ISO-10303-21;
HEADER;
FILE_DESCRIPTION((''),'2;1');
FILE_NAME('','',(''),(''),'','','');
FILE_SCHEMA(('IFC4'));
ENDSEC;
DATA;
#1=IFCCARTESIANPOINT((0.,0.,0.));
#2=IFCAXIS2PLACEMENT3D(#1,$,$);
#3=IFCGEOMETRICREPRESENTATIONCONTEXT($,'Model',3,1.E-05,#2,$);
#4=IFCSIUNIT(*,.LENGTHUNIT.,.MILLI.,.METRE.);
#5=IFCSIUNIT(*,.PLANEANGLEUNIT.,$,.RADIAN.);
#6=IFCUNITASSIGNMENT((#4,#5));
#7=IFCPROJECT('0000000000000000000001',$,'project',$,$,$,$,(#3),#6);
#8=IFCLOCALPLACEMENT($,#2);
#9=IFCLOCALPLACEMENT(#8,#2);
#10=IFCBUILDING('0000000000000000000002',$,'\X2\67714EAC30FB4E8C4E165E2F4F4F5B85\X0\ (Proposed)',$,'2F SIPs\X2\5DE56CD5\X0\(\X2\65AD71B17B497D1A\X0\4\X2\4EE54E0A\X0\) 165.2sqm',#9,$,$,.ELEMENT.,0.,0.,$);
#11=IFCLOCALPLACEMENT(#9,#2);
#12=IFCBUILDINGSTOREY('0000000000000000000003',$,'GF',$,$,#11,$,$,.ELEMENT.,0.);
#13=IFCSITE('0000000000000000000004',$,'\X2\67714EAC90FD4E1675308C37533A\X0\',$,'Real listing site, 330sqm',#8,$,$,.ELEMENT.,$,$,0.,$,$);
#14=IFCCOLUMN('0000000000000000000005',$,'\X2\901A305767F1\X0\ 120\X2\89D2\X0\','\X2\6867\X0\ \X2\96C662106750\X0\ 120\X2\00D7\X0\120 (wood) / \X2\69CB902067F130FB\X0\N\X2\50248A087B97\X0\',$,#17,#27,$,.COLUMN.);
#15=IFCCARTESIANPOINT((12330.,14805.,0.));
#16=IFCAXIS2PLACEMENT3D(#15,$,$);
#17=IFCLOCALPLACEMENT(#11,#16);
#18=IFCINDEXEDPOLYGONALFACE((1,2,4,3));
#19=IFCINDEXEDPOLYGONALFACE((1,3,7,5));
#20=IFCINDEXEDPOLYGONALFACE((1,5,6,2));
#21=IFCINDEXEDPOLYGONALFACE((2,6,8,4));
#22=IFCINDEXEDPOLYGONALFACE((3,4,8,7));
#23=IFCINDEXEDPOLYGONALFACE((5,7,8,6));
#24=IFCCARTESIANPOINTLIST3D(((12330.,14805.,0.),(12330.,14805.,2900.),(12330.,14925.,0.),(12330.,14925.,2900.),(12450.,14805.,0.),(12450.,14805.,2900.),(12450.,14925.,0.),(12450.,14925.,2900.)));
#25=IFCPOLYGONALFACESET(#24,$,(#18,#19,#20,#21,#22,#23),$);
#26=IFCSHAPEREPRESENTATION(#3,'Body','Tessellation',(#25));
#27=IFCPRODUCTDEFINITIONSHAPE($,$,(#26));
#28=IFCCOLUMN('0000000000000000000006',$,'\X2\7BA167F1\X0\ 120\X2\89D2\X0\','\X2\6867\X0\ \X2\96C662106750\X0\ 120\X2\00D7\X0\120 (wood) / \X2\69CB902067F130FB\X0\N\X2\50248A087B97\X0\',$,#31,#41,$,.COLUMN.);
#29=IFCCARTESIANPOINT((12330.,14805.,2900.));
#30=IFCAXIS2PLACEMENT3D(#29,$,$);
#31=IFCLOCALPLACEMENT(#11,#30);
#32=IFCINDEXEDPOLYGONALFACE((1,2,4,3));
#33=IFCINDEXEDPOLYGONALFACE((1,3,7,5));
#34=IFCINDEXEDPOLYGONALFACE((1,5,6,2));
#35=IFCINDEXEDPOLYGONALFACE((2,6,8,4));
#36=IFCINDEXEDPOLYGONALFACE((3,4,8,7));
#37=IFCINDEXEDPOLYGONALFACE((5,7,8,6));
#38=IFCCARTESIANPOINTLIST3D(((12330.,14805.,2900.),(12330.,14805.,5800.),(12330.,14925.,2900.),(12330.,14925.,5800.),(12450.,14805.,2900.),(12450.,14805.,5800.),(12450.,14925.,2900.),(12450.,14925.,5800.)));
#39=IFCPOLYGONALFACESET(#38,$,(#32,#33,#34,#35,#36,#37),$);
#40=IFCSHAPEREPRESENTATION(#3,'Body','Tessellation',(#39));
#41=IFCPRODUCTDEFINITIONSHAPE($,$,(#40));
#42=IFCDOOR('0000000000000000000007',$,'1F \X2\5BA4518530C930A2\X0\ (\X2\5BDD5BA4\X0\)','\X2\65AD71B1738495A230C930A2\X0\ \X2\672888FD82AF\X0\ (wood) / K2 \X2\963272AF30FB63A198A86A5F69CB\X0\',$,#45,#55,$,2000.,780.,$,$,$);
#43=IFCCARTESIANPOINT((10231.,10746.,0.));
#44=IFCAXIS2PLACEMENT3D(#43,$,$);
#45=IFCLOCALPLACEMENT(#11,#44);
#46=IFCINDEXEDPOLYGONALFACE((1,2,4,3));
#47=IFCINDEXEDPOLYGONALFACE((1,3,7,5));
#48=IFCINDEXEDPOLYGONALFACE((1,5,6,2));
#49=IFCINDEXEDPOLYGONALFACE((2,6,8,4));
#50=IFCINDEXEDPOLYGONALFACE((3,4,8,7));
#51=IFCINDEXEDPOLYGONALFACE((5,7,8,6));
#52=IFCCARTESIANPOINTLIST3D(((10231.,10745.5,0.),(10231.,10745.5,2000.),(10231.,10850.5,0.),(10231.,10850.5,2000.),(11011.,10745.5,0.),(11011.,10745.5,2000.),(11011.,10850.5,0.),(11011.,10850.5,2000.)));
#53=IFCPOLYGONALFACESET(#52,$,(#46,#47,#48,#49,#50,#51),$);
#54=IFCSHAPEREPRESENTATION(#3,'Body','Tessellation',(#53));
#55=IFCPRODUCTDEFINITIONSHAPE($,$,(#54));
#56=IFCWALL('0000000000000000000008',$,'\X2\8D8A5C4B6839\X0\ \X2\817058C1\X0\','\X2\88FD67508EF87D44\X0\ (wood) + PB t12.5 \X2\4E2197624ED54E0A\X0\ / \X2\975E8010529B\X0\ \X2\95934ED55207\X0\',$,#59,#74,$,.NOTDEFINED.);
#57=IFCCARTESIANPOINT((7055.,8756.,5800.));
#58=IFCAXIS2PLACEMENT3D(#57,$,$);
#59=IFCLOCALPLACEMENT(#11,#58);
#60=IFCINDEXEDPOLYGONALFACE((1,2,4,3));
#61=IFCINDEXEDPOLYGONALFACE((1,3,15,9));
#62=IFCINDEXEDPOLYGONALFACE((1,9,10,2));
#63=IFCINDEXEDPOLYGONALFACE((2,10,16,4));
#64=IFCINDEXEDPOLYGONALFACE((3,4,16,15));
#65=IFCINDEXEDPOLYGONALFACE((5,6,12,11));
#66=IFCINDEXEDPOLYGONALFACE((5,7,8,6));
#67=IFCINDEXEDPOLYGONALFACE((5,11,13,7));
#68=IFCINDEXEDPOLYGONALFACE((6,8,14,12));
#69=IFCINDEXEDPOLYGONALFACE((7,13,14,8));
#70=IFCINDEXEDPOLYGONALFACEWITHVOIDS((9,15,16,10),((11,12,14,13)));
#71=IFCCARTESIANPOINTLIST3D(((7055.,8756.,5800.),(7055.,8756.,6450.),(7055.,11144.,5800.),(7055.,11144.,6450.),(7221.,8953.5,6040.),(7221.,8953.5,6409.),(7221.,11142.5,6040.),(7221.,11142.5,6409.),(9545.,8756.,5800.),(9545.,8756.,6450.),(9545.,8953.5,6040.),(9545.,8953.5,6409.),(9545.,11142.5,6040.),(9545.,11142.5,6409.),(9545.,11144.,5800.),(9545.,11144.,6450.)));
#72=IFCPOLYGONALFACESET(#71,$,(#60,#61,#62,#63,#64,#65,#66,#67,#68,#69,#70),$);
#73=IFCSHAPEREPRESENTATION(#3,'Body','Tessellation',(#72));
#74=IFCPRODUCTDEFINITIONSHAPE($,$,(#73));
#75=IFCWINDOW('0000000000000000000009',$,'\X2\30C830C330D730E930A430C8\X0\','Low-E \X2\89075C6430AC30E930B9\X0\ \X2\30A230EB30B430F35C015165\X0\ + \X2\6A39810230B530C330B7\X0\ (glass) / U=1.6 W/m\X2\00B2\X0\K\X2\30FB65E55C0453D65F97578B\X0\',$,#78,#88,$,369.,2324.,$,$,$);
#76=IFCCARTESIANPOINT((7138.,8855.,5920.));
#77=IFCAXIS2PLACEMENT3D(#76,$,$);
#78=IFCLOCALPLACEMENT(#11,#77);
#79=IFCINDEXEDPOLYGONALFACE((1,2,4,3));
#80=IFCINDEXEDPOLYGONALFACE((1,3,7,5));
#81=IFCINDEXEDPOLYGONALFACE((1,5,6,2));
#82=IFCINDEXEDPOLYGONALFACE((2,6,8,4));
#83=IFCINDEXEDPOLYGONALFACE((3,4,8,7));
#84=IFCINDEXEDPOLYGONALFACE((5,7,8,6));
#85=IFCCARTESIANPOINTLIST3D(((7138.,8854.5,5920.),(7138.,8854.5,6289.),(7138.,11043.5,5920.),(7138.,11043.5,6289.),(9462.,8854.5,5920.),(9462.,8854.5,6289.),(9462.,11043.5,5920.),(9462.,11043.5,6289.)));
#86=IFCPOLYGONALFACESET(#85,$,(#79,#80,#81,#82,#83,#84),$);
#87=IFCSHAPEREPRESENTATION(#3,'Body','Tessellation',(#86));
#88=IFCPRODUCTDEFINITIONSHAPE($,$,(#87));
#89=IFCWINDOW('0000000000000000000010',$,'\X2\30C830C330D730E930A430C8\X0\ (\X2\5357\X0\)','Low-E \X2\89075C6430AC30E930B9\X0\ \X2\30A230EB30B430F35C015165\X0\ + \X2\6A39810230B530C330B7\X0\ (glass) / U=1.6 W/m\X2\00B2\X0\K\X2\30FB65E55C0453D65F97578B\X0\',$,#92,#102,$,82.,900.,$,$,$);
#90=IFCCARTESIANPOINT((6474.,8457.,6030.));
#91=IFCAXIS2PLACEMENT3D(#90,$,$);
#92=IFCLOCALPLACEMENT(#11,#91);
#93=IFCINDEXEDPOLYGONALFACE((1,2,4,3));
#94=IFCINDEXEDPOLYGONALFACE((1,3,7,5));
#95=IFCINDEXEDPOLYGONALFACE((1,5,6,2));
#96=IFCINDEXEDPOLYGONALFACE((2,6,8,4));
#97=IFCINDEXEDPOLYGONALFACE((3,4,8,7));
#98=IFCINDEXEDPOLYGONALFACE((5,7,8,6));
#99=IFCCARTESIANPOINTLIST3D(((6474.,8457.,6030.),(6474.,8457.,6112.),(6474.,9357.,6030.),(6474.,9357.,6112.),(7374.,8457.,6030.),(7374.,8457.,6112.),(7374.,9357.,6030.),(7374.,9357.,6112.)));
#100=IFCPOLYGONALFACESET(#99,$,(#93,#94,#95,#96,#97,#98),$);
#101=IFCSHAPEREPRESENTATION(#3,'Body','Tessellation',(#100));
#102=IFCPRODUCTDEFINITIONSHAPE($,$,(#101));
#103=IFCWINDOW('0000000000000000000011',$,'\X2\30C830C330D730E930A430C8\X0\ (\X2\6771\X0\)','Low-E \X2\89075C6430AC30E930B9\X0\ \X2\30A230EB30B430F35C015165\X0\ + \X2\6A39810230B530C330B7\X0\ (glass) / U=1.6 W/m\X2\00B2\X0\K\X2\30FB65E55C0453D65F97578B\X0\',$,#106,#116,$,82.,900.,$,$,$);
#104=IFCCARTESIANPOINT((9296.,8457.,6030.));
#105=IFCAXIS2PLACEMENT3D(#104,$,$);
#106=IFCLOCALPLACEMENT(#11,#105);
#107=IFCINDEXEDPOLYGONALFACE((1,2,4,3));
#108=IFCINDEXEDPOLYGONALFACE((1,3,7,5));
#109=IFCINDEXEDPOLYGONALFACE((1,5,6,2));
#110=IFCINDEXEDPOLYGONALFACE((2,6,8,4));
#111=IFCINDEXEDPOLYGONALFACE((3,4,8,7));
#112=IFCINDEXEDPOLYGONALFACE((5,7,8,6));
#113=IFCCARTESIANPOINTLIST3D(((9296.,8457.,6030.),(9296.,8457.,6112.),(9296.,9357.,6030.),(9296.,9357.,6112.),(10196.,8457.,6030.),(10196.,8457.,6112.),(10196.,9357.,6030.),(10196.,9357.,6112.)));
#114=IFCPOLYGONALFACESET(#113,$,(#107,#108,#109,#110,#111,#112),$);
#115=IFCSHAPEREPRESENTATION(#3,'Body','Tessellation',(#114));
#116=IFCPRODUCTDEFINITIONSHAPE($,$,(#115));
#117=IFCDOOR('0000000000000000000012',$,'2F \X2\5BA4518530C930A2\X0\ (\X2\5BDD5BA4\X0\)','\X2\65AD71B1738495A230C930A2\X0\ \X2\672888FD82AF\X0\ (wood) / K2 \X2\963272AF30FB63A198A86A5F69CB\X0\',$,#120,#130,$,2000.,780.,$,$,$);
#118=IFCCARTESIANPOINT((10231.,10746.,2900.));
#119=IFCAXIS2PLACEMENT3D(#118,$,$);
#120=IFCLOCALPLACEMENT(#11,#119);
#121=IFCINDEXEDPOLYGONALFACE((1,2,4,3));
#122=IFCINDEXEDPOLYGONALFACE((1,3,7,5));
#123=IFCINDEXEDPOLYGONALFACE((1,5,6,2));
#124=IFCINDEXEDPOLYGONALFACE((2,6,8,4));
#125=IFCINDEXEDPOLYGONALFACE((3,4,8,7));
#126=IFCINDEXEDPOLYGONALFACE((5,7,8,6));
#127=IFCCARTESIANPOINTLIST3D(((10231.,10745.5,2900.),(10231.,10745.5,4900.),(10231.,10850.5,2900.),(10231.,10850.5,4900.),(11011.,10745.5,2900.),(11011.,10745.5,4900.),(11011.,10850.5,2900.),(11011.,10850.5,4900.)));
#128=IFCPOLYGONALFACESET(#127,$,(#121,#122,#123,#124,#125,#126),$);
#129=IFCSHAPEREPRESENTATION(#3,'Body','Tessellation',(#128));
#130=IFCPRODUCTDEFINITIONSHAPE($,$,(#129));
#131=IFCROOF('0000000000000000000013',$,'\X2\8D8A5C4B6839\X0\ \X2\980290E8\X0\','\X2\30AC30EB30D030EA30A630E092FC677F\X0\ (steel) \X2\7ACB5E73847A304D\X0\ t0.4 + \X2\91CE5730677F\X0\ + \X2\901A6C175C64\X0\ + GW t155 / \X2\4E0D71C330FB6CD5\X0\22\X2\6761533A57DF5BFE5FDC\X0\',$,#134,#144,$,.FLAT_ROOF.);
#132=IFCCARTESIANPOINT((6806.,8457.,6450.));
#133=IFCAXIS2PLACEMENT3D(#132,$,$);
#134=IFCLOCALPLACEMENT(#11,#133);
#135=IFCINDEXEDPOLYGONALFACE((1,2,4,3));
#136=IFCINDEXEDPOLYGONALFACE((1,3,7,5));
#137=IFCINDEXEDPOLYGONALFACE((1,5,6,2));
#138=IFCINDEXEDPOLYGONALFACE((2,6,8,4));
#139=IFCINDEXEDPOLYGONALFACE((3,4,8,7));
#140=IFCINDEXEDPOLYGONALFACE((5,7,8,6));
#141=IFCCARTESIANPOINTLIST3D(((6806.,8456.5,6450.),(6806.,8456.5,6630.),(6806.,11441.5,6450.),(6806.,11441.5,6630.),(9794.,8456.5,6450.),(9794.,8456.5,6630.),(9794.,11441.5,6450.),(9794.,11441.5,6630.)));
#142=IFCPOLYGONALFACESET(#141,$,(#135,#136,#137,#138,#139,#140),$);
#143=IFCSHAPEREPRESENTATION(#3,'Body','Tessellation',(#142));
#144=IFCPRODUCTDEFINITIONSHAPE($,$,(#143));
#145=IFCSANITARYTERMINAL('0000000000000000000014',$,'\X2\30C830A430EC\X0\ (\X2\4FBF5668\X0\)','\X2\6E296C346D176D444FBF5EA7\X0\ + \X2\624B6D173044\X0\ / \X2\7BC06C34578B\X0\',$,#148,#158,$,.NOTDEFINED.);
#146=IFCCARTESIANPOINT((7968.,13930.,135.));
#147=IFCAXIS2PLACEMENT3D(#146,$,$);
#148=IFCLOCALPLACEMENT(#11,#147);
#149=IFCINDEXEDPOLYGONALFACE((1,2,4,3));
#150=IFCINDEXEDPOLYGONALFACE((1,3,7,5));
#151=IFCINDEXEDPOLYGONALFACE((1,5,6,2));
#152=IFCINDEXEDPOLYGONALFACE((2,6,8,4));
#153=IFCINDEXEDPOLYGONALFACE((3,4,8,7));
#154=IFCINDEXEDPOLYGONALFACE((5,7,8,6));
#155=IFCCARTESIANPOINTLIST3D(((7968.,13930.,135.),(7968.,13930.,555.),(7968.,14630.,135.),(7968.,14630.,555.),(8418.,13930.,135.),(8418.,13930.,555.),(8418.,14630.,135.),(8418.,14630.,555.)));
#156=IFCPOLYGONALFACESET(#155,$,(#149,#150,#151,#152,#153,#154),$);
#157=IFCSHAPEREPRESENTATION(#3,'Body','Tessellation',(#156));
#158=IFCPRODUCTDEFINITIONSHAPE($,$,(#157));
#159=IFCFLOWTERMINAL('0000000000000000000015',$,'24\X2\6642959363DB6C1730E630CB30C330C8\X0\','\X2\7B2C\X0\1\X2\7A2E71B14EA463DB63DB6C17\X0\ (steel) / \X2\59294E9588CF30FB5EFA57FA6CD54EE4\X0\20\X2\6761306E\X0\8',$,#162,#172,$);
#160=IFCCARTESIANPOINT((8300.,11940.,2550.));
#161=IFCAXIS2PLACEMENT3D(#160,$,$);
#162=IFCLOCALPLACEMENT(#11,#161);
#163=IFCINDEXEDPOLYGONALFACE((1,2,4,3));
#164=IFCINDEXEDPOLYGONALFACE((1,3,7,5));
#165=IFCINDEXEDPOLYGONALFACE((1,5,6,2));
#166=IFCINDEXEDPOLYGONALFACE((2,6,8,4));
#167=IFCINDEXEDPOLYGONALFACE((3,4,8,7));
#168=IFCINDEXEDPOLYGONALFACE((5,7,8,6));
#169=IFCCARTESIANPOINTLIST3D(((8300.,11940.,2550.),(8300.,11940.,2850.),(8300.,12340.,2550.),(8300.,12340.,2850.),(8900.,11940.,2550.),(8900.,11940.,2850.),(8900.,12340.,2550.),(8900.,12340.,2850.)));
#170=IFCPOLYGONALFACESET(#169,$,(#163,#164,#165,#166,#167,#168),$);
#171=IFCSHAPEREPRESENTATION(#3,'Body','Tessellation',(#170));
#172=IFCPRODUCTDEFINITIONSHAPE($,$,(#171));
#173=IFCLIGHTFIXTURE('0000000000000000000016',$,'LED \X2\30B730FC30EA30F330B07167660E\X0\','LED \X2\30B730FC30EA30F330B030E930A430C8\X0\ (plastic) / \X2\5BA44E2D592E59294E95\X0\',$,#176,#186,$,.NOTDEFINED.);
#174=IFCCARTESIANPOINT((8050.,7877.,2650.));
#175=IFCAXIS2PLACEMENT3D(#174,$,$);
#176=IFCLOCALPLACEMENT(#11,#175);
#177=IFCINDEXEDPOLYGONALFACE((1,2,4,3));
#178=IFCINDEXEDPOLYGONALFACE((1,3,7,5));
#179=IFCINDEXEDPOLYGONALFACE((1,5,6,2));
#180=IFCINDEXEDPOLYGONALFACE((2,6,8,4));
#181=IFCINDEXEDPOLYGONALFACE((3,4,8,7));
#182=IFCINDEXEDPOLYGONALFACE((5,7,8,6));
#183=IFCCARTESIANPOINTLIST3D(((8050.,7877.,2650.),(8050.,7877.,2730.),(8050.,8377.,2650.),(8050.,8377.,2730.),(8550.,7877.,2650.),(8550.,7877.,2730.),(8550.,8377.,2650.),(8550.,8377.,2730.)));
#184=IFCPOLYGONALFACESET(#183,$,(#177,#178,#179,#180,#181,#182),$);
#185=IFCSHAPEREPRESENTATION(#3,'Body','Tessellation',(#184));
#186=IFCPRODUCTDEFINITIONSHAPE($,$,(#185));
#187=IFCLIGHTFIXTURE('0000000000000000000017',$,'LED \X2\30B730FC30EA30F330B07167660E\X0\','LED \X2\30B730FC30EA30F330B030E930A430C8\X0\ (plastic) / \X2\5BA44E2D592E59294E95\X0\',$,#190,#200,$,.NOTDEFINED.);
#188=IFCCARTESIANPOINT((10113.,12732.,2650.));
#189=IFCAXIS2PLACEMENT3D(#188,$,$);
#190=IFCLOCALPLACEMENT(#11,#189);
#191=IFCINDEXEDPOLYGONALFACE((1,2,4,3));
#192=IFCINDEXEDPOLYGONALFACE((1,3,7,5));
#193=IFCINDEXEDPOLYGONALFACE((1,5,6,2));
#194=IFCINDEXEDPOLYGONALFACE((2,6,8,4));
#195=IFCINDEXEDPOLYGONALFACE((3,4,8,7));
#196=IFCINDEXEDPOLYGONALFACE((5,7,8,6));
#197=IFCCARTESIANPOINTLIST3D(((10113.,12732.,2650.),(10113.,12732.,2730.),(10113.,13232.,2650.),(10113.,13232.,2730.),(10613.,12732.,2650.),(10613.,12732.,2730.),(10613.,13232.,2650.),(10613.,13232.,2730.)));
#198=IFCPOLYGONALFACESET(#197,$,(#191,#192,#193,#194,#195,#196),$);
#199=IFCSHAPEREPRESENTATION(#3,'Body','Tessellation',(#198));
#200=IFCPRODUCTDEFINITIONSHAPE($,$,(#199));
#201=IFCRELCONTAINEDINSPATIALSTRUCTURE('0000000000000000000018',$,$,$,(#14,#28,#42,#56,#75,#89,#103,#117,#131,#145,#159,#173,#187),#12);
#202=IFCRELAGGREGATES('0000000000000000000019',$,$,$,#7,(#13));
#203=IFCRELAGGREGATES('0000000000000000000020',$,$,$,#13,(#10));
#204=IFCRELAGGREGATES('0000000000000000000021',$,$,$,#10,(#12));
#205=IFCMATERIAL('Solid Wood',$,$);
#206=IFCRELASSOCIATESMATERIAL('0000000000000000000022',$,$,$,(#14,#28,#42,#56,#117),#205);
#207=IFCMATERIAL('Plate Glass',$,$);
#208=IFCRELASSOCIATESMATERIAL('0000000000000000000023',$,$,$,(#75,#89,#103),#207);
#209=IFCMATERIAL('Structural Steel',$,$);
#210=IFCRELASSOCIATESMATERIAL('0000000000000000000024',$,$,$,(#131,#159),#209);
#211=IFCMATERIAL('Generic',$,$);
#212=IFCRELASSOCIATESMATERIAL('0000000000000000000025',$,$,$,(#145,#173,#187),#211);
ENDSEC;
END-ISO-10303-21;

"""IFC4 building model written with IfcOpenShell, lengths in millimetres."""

from ifc_helpers import new_model, si_unit, frame, frame_2d, origin, place, context, project, spatial, rectangle, extrude, material, element, fill, save


model = new_model("IFC4")

# Units and contexts
model_context = context("Model", 3, precision=1e-05, world=origin())
ifc_project = project(units=[si_unit("LENGTHUNIT", "METRE", prefix="MILLI"), si_unit("PLANEANGLEUNIT", "RADIAN")], contexts=[model_context])

# Site, building, storey
site_placement = place(None, origin())
site = spatial("IfcSite", under=ifc_project, at=site_placement, Name="東京都世田谷区", ObjectType="Real listing site, 330sqm", CompositionType="ELEMENT", RefElevation=0.0)
building_placement = place(site_placement, origin())
building = spatial("IfcBuilding", under=site, at=building_placement, Name="東京・二世帯住宅 (Proposed)", ObjectType="2F SIPs工法(断熱等級4以上) 165.2sqm", CompositionType="ELEMENT", ElevationOfRefHeight=0.0, ElevationOfTerrain=0.0)
storey_placement = place(building_placement, origin())
storey = spatial("IfcBuildingStorey", under=building, at=storey_placement, Name="GF", CompositionType="ELEMENT", Elevation=0.0)

# Columns
ifc_material_1 = material(Name="Solid Wood")
column_1_placement = place(storey_placement, frame((12330.0, 14805.0, 0.0)))
element("IfcColumn", 1, at=column_1_placement, inside=storey, material=ifc_material_1, Name="通し柱 120角", Description="桧 集成材 120×120 (wood) / 構造柱・N値計算", PredefinedType="COLUMN", context=model_context, shape_type="SweptSolid", body=[
    extrude(rectangle(XDim=120.0, YDim=120.0, at=frame_2d((60.0, 60.0))), frame((12330.0, 14805.0, 0.0)), (0.0, 0.0, 1.0), 2900.0),
])
column_2_placement = place(storey_placement, frame((12330.0, 14805.0, 2900.0)))
element("IfcColumn", 2, at=column_2_placement, inside=storey, material=ifc_material_1, Name="管柱 120角", Description="桧 集成材 120×120 (wood) / 構造柱・N値計算", PredefinedType="COLUMN", context=model_context, shape_type="SweptSolid", body=[
    extrude(rectangle(XDim=120.0, YDim=120.0, at=frame_2d((60.0, 60.0))), frame((12330.0, 14805.0, 2900.0)), (0.0, 0.0, 1.0), 2900.0),
])

# Door
door_1_placement = place(storey_placement, frame((10231.0, 10746.0, 0.0)))
element("IfcDoor", 3, at=door_1_placement, inside=storey, material=ifc_material_1, Name="1F 室内ドア (寝室)", Description="断熱玄関ドア 木製芯 (wood) / K2 防犯・採風機構", OverallHeight=2000.0, OverallWidth=780.0, context=model_context, shape_type="SweptSolid", body=[
    extrude(rectangle(XDim=780.0, YDim=105.0, at=frame_2d((390.0, 52.0))), frame((10231.0, 10746.0, 0.0)), (0.0, 0.0, 1.0), 2000.0),
])

# Wall, openings, windows
wall_1_placement = place(storey_placement, frame((7055.0, 8756.0, 5800.0)))
wall_1 = element("IfcWall", 4, at=wall_1_placement, inside=storey, material=ifc_material_1, Name="越屋根 腰壁", Description="製材軸組 (wood) + PB t12.5 両面仕上 / 非耐力 間仕切", PredefinedType="NOTDEFINED", context=model_context, shape_type="SweptSolid", body=[
    extrude(rectangle(XDim=2490.0, YDim=2388.0, at=frame_2d((1245.0, 1194.0))), frame((7055.0, 8756.0, 5800.0)), (0.0, 0.0, 1.0), 650.0),
])
opening_1_placement = place(storey_placement, frame((7138.0, 8855.0, 5920.0)))
opening_1 = element("IfcOpeningElement", 5, at=opening_1_placement, cuts=wall_1, PredefinedType="NOTDEFINED", context=model_context, shape_type="SweptSolid", body=[
    extrude(rectangle(XDim=2324.0, YDim=2189.0, at=frame_2d((1162.0, 1094.0))), frame((7138.0, 8855.0, 5920.0)), (0.0, 0.0, 1.0), 369.0),
])
opening_2_placement = place(storey_placement, frame((6474.0, 8457.0, 6030.0)))
opening_2 = element("IfcOpeningElement", 6, at=opening_2_placement, cuts=wall_1, PredefinedType="NOTDEFINED", context=model_context, shape_type="SweptSolid", body=[
    extrude(rectangle(XDim=900.0, YDim=900.0, at=frame_2d((450.0, 450.0))), frame((6474.0, 8457.0, 6030.0)), (0.0, 0.0, 1.0), 82.0),
])
opening_3_placement = place(storey_placement, frame((9296.0, 8457.0, 6030.0)))
opening_3 = element("IfcOpeningElement", 7, at=opening_3_placement, cuts=wall_1, PredefinedType="NOTDEFINED", context=model_context, shape_type="SweptSolid", body=[
    extrude(rectangle(XDim=900.0, YDim=900.0, at=frame_2d((450.0, 450.0))), frame((9296.0, 8457.0, 6030.0)), (0.0, 0.0, 1.0), 82.0),
])
ifc_material_2 = material(Name="Plate Glass")
window_1_placement = place(storey_placement, frame((7138.0, 8855.0, 5920.0)))
window_1 = element("IfcWindow", 8, at=window_1_placement, inside=storey, material=ifc_material_2, Name="トップライト", Description="Low-E 複層ガラス アルゴン封入 + 樹脂サッシ (glass) / U=1.6 W/m²K・日射取得型", OverallHeight=369.0, OverallWidth=2324.0, context=model_context, shape_type="SweptSolid", body=[
    extrude(rectangle(XDim=2324.0, YDim=2189.0, at=frame_2d((1162.0, 1094.0))), frame((7138.0, 8855.0, 5920.0)), (0.0, 0.0, 1.0), 369.0),
])
fill(opening_1, window_1)
window_2_placement = place(storey_placement, frame((6474.0, 8457.0, 6030.0)))
window_2 = element("IfcWindow", 9, at=window_2_placement, inside=storey, material=ifc_material_2, Name="トップライト (南)", Description="Low-E 複層ガラス アルゴン封入 + 樹脂サッシ (glass) / U=1.6 W/m²K・日射取得型", OverallHeight=82.0, OverallWidth=900.0, context=model_context, shape_type="SweptSolid", body=[
    extrude(rectangle(XDim=900.0, YDim=900.0, at=frame_2d((450.0, 450.0))), frame((6474.0, 8457.0, 6030.0)), (0.0, 0.0, 1.0), 82.0),
])
fill(opening_2, window_2)
window_3_placement = place(storey_placement, frame((9296.0, 8457.0, 6030.0)))
window_3 = element("IfcWindow", 10, at=window_3_placement, inside=storey, material=ifc_material_2, Name="トップライト (東)", Description="Low-E 複層ガラス アルゴン封入 + 樹脂サッシ (glass) / U=1.6 W/m²K・日射取得型", OverallHeight=82.0, OverallWidth=900.0, context=model_context, shape_type="SweptSolid", body=[
    extrude(rectangle(XDim=900.0, YDim=900.0, at=frame_2d((450.0, 450.0))), frame((9296.0, 8457.0, 6030.0)), (0.0, 0.0, 1.0), 82.0),
])
fill(opening_3, window_3)

# Door
door_2_placement = place(storey_placement, frame((10231.0, 10746.0, 2900.0)))
element("IfcDoor", 11, at=door_2_placement, inside=storey, material=ifc_material_1, Name="2F 室内ドア (寝室)", Description="断熱玄関ドア 木製芯 (wood) / K2 防犯・採風機構", OverallHeight=2000.0, OverallWidth=780.0, context=model_context, shape_type="SweptSolid", body=[
    extrude(rectangle(XDim=780.0, YDim=105.0, at=frame_2d((390.0, 52.0))), frame((10231.0, 10746.0, 2900.0)), (0.0, 0.0, 1.0), 2000.0),
])

# Roof
ifc_material_3 = material(Name="Structural Steel")
roof_placement = place(storey_placement, frame((6806.0, 8457.0, 6450.0)))
element("IfcRoof", 12, at=roof_placement, inside=storey, material=ifc_material_3, Name="越屋根 頂部", Description="ガルバリウム鋼板 (steel) 立平葺き t0.4 + 野地板 + 通気層 + GW t155 / 不燃・法22条区域対応", PredefinedType="FLAT_ROOF", context=model_context, shape_type="SweptSolid", body=[
    extrude(rectangle(XDim=2988.0, YDim=2985.0, at=frame_2d((1494.0, 1492.0))), frame((6806.0, 8457.0, 6450.0)), (0.0, 0.0, 1.0), 180.0),
])

# Sanitary terminal
ifc_material_4 = material(Name="Generic")
sanitary_terminal_placement = place(storey_placement, frame((7968.0, 13930.0, 135.0)))
element("IfcSanitaryTerminal", 13, at=sanitary_terminal_placement, inside=storey, material=ifc_material_4, Name="トイレ (便器)", Description="温水洗浄便座 + 手洗い / 節水型", PredefinedType="NOTDEFINED", context=model_context, shape_type="SweptSolid", body=[
    extrude(rectangle(XDim=450.0, YDim=700.0, at=frame_2d((225.0, 350.0))), frame((7968.0, 13930.0, 135.0)), (0.0, 0.0, 1.0), 420.0),
])

# Flow terminal
flow_terminal_placement = place(storey_placement, frame((8300.0, 11940.0, 2550.0)))
element("IfcFlowTerminal", 14, at=flow_terminal_placement, inside=storey, material=ifc_material_3, Name="24時間換気ユニット", Description="第1種熱交換換気 (steel) / 天井裏・建基法令20条の8", context=model_context, shape_type="SweptSolid", body=[
    extrude(rectangle(XDim=600.0, YDim=400.0, at=frame_2d((300.0, 200.0))), frame((8300.0, 11940.0, 2550.0)), (0.0, 0.0, 1.0), 300.0),
])

# Light fixtures
light_fixture_1_placement = place(storey_placement, frame((8050.0, 7877.0, 2650.0)))
element("IfcLightFixture", 15, at=light_fixture_1_placement, inside=storey, material=ifc_material_4, Name="LED シーリング照明", Description="LED シーリングライト (plastic) / 室中央天井", PredefinedType="NOTDEFINED", context=model_context, shape_type="SweptSolid", body=[
    extrude(rectangle(XDim=500.0, YDim=500.0, at=frame_2d((250.0, 250.0))), frame((8050.0, 7877.0, 2650.0)), (0.0, 0.0, 1.0), 80.0),
])
light_fixture_2_placement = place(storey_placement, frame((10113.0, 12732.0, 2650.0)))
element("IfcLightFixture", 16, at=light_fixture_2_placement, inside=storey, material=ifc_material_4, Name="LED シーリング照明", Description="LED シーリングライト (plastic) / 室中央天井", PredefinedType="NOTDEFINED", context=model_context, shape_type="SweptSolid", body=[
    extrude(rectangle(XDim=500.0, YDim=500.0, at=frame_2d((250.0, 250.0))), frame((10113.0, 12732.0, 2650.0)), (0.0, 0.0, 1.0), 80.0),
])

save(model, "model.ifc")
